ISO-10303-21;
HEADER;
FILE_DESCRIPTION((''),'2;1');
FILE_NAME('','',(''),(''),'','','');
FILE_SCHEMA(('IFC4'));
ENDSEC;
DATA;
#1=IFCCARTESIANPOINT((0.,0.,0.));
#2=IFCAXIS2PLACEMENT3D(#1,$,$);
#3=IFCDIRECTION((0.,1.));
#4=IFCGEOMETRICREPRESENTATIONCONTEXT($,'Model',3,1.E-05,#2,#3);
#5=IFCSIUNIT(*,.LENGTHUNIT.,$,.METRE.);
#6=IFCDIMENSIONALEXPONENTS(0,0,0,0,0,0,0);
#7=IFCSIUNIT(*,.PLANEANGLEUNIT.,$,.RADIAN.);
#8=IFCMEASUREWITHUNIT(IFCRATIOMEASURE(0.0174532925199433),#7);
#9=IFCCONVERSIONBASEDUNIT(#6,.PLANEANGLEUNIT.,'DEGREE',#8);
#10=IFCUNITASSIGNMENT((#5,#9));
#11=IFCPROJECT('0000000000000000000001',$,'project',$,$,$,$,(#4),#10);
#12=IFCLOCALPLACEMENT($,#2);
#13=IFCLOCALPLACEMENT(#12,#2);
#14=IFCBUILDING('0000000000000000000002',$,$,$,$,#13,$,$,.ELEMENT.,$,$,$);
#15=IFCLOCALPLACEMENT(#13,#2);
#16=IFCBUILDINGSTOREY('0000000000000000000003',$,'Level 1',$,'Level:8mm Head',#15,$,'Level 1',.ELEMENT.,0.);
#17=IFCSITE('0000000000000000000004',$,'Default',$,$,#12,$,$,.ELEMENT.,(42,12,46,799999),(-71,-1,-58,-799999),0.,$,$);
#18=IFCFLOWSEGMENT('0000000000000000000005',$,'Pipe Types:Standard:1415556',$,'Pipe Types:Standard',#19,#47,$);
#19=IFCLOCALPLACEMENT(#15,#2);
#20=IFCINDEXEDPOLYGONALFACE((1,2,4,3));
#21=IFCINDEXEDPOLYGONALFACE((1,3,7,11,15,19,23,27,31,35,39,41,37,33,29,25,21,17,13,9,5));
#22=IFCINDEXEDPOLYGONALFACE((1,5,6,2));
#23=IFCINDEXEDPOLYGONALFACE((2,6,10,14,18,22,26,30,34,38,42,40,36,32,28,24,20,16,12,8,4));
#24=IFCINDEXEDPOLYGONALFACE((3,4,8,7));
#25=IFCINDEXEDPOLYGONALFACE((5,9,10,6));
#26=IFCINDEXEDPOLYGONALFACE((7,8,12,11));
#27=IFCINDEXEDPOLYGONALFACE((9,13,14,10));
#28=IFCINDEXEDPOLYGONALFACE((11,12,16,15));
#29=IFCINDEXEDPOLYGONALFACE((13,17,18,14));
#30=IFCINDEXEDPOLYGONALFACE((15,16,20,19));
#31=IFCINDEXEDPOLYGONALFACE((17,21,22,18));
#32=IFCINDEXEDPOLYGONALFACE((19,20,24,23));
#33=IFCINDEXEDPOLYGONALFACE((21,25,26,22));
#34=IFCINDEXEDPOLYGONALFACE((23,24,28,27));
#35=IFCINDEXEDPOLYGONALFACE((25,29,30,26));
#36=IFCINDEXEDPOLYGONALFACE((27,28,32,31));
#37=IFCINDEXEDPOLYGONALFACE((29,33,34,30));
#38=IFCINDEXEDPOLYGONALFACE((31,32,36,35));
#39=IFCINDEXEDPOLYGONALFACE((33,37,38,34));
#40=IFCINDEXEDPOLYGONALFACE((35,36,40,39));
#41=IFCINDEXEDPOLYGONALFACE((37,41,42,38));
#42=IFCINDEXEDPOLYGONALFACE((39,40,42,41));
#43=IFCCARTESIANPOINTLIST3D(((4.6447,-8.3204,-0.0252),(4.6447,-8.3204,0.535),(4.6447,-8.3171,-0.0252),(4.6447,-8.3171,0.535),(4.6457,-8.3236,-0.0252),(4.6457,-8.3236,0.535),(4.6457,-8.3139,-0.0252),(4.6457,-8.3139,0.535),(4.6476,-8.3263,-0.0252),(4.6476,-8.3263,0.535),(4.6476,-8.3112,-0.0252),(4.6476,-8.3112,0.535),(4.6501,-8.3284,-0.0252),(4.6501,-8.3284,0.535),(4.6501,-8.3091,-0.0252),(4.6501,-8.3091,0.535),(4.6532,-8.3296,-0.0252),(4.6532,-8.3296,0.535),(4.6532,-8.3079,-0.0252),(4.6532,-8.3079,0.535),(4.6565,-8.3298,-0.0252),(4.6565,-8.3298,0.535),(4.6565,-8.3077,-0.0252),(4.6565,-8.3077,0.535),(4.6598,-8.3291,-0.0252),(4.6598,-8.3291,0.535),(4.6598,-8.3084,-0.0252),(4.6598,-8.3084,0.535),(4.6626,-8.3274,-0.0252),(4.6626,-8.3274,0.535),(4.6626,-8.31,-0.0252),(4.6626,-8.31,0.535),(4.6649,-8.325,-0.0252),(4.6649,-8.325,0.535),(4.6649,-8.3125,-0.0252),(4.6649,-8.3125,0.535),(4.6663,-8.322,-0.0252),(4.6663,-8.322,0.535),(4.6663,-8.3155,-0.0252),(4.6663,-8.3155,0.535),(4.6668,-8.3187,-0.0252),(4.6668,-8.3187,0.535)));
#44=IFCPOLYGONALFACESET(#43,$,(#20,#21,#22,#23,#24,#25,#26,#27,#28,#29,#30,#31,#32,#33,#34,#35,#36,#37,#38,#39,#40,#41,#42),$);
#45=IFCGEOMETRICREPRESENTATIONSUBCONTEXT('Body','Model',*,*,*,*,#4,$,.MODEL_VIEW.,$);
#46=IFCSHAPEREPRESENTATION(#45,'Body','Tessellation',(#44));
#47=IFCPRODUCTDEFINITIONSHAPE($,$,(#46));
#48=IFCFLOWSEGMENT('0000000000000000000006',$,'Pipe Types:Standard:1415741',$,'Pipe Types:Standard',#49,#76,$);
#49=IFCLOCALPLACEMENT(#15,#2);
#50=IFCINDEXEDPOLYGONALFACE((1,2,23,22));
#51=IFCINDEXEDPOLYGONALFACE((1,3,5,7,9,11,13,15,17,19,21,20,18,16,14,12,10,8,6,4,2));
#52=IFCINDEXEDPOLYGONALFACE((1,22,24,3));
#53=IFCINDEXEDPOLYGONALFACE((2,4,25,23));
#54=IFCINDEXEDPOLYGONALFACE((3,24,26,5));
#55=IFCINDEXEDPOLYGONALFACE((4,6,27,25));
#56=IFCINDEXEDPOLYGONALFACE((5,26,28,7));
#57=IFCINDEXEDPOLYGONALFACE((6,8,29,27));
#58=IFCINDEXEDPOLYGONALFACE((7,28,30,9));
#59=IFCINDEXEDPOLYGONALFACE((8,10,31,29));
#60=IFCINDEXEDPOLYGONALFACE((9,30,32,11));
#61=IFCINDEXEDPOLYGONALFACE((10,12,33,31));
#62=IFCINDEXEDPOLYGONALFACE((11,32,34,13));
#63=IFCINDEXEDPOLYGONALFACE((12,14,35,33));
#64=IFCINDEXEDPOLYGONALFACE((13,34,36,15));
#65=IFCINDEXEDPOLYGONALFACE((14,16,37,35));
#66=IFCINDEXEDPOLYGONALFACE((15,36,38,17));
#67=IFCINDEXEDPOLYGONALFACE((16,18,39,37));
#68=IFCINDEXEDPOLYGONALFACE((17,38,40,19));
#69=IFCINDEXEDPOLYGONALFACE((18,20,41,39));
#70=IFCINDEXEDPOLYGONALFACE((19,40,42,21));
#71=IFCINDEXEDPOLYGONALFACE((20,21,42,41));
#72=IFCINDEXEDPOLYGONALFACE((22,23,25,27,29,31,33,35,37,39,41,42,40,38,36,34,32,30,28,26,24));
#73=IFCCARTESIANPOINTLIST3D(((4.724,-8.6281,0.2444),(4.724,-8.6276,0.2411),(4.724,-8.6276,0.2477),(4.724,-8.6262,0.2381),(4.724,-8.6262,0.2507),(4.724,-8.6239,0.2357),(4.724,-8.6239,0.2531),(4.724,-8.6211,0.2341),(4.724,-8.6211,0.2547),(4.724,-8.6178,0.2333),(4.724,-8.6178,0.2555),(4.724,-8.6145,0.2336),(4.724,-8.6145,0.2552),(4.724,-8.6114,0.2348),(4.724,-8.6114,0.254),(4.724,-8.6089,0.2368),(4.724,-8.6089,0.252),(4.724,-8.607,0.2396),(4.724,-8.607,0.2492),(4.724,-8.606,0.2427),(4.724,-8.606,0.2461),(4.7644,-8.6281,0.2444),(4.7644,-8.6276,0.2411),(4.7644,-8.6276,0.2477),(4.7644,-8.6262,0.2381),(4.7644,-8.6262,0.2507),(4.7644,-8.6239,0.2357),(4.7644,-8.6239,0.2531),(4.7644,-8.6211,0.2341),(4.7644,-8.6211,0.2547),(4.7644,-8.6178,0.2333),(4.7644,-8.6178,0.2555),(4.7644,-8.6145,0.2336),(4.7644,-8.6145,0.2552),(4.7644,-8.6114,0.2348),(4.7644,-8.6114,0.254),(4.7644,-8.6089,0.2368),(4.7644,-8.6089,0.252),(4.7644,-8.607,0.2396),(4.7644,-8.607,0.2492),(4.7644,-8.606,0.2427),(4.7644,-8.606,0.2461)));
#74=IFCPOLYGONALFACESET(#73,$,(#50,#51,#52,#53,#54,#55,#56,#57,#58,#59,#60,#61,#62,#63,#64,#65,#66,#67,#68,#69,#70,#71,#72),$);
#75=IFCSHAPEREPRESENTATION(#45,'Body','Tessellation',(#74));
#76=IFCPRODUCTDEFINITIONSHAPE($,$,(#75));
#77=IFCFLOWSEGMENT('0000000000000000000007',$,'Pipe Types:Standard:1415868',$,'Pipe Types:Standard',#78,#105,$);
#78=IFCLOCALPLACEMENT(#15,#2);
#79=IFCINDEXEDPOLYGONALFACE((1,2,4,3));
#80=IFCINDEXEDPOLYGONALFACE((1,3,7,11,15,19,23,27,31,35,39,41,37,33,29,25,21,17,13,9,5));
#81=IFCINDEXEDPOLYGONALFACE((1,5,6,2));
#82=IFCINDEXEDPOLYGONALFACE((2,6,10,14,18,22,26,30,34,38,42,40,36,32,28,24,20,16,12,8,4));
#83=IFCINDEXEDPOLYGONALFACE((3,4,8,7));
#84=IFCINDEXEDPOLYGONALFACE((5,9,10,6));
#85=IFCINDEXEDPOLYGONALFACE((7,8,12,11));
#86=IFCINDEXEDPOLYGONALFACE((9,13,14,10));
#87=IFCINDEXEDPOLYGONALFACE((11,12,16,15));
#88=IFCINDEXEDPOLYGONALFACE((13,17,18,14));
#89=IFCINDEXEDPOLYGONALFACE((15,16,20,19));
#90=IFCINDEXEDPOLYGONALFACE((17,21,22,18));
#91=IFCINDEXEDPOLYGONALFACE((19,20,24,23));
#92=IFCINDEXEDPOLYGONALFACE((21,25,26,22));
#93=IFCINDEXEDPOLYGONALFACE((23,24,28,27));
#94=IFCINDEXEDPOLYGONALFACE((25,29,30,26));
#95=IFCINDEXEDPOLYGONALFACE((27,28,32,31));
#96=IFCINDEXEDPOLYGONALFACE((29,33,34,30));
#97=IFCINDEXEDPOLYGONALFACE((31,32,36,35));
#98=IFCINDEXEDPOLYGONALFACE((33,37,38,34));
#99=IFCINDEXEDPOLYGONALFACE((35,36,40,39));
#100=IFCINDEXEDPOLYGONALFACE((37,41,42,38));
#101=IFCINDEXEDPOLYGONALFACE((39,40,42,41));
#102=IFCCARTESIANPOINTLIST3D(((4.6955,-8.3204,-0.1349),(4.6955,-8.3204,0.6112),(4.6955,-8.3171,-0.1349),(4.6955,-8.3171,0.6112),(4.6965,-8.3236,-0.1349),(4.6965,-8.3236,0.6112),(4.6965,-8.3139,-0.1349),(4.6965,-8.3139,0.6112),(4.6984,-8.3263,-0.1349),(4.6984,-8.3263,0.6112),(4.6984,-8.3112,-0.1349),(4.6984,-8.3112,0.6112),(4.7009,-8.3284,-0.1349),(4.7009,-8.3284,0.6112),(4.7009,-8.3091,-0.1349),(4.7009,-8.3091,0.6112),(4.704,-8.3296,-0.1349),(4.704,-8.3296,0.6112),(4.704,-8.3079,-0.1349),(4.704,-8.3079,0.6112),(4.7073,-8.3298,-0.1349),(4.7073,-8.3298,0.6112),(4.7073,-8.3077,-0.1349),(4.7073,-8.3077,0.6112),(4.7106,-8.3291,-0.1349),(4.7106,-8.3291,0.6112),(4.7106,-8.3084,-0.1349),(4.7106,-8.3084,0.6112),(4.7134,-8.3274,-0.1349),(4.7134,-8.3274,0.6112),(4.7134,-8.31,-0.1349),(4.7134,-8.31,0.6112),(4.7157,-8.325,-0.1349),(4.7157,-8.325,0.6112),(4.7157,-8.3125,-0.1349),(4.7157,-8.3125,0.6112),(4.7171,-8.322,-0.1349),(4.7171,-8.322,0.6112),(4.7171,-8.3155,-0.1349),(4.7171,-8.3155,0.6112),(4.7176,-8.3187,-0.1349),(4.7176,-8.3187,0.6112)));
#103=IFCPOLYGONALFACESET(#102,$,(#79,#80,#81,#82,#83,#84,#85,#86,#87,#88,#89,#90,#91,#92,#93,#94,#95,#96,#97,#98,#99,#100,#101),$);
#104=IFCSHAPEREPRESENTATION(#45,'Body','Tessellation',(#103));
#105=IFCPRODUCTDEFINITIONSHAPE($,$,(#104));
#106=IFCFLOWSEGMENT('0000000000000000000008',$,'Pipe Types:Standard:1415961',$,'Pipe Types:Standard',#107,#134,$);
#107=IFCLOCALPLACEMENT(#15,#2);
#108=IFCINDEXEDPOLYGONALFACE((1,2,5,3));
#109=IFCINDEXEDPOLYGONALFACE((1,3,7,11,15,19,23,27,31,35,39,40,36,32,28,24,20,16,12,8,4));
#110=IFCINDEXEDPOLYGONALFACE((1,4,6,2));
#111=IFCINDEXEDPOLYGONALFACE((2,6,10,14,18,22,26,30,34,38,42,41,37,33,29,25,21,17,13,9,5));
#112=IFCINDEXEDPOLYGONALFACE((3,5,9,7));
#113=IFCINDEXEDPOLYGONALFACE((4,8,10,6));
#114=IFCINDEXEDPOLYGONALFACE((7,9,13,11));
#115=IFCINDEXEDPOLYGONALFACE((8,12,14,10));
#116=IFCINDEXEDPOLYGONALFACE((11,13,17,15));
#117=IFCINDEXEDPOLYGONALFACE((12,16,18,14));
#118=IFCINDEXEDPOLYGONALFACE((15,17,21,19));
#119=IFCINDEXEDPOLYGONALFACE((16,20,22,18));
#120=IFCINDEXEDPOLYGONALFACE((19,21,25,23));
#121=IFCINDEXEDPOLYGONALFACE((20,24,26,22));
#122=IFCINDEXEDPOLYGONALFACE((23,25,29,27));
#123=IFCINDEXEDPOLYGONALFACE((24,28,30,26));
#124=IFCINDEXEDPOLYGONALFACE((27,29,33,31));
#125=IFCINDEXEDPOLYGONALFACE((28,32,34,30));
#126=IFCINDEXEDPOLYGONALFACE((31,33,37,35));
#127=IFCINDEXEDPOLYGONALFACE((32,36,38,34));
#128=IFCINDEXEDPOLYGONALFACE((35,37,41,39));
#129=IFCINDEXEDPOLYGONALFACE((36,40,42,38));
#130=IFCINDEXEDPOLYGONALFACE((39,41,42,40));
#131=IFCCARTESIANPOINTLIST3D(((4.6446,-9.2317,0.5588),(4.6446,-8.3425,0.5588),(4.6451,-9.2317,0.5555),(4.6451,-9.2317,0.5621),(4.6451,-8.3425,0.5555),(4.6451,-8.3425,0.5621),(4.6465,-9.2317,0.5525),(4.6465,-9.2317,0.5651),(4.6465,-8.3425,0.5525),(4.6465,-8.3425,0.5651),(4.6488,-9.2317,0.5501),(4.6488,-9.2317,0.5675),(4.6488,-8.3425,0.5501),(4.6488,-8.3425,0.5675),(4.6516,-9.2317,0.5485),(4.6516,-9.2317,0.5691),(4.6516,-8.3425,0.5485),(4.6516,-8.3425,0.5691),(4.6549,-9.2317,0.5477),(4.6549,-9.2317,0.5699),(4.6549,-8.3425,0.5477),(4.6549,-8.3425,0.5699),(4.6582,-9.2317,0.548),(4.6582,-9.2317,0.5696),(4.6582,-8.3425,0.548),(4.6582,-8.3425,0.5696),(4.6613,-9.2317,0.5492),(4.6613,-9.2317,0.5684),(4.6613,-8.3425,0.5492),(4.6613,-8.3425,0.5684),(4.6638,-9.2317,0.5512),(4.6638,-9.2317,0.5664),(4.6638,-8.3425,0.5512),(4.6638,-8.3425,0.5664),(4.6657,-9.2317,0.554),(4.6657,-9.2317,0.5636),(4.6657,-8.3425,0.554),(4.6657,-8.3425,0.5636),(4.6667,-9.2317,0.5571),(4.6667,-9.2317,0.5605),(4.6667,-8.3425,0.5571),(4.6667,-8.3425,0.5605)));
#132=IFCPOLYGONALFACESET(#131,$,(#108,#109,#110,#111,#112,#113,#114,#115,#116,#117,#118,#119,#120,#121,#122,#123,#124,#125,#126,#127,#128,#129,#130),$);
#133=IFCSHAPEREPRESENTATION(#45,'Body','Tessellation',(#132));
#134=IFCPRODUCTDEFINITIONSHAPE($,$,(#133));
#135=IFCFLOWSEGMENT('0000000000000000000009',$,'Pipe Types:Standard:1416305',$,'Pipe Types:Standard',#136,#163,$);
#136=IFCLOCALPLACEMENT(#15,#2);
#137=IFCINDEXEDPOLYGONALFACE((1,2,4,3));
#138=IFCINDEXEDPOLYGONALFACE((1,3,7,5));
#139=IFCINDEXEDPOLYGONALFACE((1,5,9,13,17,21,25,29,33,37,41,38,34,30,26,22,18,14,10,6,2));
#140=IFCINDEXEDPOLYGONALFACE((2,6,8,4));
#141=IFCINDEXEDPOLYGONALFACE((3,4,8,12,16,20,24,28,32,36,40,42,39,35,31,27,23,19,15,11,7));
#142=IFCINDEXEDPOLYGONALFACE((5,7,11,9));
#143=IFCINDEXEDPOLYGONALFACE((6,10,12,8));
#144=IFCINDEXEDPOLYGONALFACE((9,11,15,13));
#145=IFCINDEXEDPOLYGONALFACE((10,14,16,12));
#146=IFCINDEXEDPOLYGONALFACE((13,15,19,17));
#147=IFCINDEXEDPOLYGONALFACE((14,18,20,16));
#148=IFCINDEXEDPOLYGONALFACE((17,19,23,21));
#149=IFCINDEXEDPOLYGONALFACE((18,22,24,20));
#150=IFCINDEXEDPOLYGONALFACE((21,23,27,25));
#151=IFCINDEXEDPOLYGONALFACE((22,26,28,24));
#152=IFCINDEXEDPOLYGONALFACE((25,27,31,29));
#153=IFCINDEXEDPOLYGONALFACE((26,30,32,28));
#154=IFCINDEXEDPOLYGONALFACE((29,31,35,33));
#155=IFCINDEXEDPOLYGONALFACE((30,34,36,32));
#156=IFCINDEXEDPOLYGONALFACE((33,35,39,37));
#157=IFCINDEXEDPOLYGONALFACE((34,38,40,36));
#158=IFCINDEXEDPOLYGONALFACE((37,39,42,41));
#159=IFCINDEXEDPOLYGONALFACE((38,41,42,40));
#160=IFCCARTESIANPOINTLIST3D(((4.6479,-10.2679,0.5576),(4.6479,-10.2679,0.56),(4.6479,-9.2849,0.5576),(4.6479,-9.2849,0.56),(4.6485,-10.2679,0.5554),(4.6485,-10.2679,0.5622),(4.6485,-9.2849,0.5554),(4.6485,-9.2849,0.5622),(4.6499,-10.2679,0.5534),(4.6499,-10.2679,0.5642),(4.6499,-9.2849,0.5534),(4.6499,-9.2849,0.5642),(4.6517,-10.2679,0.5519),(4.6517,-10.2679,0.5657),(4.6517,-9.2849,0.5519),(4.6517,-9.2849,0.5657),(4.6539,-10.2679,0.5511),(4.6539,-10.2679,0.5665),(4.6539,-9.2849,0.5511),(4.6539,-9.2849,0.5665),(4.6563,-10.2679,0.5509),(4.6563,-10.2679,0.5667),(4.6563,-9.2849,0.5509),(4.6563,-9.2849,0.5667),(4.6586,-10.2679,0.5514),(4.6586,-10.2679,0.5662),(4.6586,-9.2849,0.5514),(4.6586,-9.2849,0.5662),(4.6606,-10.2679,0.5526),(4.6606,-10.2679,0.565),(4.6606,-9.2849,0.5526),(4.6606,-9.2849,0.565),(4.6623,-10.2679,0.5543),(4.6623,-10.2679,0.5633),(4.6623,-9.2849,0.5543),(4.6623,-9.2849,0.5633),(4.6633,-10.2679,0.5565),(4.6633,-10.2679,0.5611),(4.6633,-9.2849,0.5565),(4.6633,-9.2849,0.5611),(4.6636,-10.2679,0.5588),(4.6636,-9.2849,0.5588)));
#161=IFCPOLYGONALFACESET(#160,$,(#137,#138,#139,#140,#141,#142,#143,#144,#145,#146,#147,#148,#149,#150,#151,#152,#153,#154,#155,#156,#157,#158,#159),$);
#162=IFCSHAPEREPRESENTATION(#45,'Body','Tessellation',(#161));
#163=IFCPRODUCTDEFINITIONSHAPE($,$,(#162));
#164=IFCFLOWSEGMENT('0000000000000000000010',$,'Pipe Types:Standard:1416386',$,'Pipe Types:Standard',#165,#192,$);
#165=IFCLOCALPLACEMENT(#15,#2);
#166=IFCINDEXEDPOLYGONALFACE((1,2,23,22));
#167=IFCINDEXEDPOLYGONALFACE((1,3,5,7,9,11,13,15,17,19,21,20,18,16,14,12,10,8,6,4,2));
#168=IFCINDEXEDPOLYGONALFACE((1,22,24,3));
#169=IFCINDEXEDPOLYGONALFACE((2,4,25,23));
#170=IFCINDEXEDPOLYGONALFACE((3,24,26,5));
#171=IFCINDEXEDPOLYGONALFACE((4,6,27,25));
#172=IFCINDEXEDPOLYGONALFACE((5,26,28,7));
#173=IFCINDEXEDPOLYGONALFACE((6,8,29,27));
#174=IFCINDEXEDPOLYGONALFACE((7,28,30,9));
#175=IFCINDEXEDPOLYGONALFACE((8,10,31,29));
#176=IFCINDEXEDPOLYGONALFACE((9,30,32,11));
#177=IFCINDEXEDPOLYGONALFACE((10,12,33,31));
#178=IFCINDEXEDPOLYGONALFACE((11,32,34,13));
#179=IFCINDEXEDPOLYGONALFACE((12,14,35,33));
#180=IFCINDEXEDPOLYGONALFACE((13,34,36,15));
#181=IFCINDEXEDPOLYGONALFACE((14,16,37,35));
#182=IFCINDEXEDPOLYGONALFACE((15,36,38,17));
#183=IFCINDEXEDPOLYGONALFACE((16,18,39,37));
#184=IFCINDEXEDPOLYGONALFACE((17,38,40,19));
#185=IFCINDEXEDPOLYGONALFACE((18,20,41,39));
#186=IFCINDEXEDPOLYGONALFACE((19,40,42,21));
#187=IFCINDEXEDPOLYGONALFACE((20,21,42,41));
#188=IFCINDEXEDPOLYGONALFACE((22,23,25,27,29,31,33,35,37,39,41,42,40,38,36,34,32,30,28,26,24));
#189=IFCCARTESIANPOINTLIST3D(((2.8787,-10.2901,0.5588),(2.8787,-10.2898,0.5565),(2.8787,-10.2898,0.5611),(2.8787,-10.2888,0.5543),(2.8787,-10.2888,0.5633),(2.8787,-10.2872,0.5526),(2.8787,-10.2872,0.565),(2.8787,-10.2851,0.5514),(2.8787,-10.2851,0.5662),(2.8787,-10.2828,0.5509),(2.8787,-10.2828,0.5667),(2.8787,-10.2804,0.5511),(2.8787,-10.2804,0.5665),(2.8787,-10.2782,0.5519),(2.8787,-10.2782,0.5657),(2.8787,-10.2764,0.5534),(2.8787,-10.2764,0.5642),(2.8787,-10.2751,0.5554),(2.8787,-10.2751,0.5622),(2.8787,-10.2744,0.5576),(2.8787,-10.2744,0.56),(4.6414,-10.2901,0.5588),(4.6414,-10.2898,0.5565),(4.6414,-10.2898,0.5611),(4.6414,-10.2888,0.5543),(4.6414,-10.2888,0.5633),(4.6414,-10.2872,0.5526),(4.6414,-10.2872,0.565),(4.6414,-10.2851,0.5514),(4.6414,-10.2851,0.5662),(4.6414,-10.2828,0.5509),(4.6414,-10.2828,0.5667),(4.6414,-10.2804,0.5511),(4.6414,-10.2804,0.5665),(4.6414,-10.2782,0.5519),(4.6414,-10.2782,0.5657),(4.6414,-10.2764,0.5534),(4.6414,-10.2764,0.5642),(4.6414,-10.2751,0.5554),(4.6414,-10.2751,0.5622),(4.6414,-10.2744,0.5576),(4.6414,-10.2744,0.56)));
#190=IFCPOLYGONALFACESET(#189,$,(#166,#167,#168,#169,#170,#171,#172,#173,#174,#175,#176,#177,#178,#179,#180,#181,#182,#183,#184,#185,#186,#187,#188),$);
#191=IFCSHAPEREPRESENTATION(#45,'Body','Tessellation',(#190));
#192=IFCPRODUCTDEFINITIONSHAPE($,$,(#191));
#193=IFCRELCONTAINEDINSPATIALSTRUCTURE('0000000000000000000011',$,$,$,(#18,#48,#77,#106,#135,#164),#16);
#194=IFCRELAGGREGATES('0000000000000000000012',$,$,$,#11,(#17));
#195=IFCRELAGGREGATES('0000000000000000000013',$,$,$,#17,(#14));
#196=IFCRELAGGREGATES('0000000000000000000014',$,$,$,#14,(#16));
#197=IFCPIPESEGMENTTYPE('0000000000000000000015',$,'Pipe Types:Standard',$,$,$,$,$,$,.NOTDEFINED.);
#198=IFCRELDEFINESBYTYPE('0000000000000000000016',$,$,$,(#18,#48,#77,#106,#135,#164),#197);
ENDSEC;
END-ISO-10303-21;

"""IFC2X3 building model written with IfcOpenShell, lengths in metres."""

from ifc_helpers import new_model, entity, si_unit, converted_unit, direction, frame, frame_2d, origin, origin_2d_with_axis, place, context, subcontext, project, spatial, circle, extrude, type_object, element, save


model = new_model("IFC2X3")

# Units and contexts
model_context = context("Model", 3, precision=1e-05, world=origin(), true_north=direction((0.0, 1.0)))
body_context = subcontext(model_context, "Body", "Model", "MODEL_VIEW")
ifc_project = project(units=[si_unit("LENGTHUNIT", "METRE"), converted_unit("PLANEANGLEUNIT", "DEGREE", entity("IfcRatioMeasure", 0.0174532925199433), si_unit("PLANEANGLEUNIT", "RADIAN"), dimensions=[0, 0, 0, 0, 0, 0, 0])], contexts=[model_context])

# Site, building, storey
site_placement = place(None, origin())
site = spatial("IfcSite", under=ifc_project, at=site_placement, Name="Default", CompositionType="ELEMENT", RefLatitude=(42, 12, 46, 799999), RefLongitude=(-71, -1, -58, -799999), RefElevation=0.0)
building_placement = place(site_placement, origin())
building = spatial("IfcBuilding", under=site, at=building_placement, CompositionType="ELEMENT")
storey_placement = place(building_placement, origin())
storey = spatial("IfcBuildingStorey", under=building, at=storey_placement, Name="Level 1", ObjectType="Level:8mm Head", LongName="Level 1", CompositionType="ELEMENT", Elevation=0.0)

# Flow segments
pipe_segment_type = type_object("IfcPipeSegmentType", Name="Pipe Types:Standard", PredefinedType="NOTDEFINED")
flow_segment_1_placement = place(storey_placement, origin())
element("IfcFlowSegment", 1, at=flow_segment_1_placement, inside=storey, type_object=pipe_segment_type, Name="Pipe Types:Standard:1415556", ObjectType="Pipe Types:Standard", context=body_context, shape_type="SweptSolid", body=[
    extrude(circle(Radius=0.0111, at=frame_2d((0.0, 0.0), x_axis=(1.0, 0.0))), frame((4.6557, -8.3187, -0.0252)), (0.0, 0.0, 1.0), 0.5602),
])
flow_segment_2_placement = place(storey_placement, origin())
element("IfcFlowSegment", 2, at=flow_segment_2_placement, inside=storey, type_object=pipe_segment_type, Name="Pipe Types:Standard:1415741", ObjectType="Pipe Types:Standard", context=body_context, shape_type="SweptSolid", body=[
    extrude(circle(Radius=0.0111, at=frame_2d((0.0, 0.0), x_axis=(1.0, 0.0))), frame((4.724, -8.617, 0.2444), z_axis=(1.0, 0.0, 0.0), x_axis=(0.0, -1.0, 0.0)), (0.0, 0.0, 1.0), 0.0405),
])
flow_segment_3_placement = place(storey_placement, origin())
element("IfcFlowSegment", 3, at=flow_segment_3_placement, inside=storey, type_object=pipe_segment_type, Name="Pipe Types:Standard:1415868", ObjectType="Pipe Types:Standard", context=body_context, shape_type="SweptSolid", body=[
    extrude(circle(Radius=0.0111, at=origin_2d_with_axis()), frame((4.7065, -8.3187, -0.1349)), (0.0, 0.0, 1.0), 0.7461),
])
flow_segment_4_placement = place(storey_placement, origin())
element("IfcFlowSegment", 4, at=flow_segment_4_placement, inside=storey, type_object=pipe_segment_type, Name="Pipe Types:Standard:1415961", ObjectType="Pipe Types:Standard", context=body_context, shape_type="SweptSolid", body=[
    extrude(circle(Radius=0.0111, at=frame_2d((0.0, 0.0), x_axis=(1.0, 0.0))), frame((4.6557, -9.2317, 0.5588), z_axis=(0.0, 1.0, 0.0), x_axis=(-1.0, 0.0, 0.0)), (0.0, 0.0, 1.0), 0.8891),
])
flow_segment_5_placement = place(storey_placement, origin())
element("IfcFlowSegment", 5, at=flow_segment_5_placement, inside=storey, type_object=pipe_segment_type, Name="Pipe Types:Standard:1416305", ObjectType="Pipe Types:Standard", context=body_context, shape_type="SweptSolid", body=[
    extrude(circle(Radius=0.0079, at=origin_2d_with_axis()), frame((4.6557, -10.2679, 0.5588), z_axis=(0.0, 1.0, 0.0), x_axis=(1.0, 0.0, 0.0)), (0.0, 0.0, 1.0), 0.983),
])
flow_segment_6_placement = place(storey_placement, origin())
element("IfcFlowSegment", 6, at=flow_segment_6_placement, inside=storey, type_object=pipe_segment_type, Name="Pipe Types:Standard:1416386", ObjectType="Pipe Types:Standard", context=body_context, shape_type="SweptSolid", body=[
    extrude(circle(Radius=0.0079, at=origin_2d_with_axis()), frame((2.8787, -10.2822, 0.5588), z_axis=(1.0, 0.0, 0.0), x_axis=(0.0, -1.0, 0.0)), (0.0, 0.0, 1.0), 1.7627),
])

save(model, "model.ifc")
